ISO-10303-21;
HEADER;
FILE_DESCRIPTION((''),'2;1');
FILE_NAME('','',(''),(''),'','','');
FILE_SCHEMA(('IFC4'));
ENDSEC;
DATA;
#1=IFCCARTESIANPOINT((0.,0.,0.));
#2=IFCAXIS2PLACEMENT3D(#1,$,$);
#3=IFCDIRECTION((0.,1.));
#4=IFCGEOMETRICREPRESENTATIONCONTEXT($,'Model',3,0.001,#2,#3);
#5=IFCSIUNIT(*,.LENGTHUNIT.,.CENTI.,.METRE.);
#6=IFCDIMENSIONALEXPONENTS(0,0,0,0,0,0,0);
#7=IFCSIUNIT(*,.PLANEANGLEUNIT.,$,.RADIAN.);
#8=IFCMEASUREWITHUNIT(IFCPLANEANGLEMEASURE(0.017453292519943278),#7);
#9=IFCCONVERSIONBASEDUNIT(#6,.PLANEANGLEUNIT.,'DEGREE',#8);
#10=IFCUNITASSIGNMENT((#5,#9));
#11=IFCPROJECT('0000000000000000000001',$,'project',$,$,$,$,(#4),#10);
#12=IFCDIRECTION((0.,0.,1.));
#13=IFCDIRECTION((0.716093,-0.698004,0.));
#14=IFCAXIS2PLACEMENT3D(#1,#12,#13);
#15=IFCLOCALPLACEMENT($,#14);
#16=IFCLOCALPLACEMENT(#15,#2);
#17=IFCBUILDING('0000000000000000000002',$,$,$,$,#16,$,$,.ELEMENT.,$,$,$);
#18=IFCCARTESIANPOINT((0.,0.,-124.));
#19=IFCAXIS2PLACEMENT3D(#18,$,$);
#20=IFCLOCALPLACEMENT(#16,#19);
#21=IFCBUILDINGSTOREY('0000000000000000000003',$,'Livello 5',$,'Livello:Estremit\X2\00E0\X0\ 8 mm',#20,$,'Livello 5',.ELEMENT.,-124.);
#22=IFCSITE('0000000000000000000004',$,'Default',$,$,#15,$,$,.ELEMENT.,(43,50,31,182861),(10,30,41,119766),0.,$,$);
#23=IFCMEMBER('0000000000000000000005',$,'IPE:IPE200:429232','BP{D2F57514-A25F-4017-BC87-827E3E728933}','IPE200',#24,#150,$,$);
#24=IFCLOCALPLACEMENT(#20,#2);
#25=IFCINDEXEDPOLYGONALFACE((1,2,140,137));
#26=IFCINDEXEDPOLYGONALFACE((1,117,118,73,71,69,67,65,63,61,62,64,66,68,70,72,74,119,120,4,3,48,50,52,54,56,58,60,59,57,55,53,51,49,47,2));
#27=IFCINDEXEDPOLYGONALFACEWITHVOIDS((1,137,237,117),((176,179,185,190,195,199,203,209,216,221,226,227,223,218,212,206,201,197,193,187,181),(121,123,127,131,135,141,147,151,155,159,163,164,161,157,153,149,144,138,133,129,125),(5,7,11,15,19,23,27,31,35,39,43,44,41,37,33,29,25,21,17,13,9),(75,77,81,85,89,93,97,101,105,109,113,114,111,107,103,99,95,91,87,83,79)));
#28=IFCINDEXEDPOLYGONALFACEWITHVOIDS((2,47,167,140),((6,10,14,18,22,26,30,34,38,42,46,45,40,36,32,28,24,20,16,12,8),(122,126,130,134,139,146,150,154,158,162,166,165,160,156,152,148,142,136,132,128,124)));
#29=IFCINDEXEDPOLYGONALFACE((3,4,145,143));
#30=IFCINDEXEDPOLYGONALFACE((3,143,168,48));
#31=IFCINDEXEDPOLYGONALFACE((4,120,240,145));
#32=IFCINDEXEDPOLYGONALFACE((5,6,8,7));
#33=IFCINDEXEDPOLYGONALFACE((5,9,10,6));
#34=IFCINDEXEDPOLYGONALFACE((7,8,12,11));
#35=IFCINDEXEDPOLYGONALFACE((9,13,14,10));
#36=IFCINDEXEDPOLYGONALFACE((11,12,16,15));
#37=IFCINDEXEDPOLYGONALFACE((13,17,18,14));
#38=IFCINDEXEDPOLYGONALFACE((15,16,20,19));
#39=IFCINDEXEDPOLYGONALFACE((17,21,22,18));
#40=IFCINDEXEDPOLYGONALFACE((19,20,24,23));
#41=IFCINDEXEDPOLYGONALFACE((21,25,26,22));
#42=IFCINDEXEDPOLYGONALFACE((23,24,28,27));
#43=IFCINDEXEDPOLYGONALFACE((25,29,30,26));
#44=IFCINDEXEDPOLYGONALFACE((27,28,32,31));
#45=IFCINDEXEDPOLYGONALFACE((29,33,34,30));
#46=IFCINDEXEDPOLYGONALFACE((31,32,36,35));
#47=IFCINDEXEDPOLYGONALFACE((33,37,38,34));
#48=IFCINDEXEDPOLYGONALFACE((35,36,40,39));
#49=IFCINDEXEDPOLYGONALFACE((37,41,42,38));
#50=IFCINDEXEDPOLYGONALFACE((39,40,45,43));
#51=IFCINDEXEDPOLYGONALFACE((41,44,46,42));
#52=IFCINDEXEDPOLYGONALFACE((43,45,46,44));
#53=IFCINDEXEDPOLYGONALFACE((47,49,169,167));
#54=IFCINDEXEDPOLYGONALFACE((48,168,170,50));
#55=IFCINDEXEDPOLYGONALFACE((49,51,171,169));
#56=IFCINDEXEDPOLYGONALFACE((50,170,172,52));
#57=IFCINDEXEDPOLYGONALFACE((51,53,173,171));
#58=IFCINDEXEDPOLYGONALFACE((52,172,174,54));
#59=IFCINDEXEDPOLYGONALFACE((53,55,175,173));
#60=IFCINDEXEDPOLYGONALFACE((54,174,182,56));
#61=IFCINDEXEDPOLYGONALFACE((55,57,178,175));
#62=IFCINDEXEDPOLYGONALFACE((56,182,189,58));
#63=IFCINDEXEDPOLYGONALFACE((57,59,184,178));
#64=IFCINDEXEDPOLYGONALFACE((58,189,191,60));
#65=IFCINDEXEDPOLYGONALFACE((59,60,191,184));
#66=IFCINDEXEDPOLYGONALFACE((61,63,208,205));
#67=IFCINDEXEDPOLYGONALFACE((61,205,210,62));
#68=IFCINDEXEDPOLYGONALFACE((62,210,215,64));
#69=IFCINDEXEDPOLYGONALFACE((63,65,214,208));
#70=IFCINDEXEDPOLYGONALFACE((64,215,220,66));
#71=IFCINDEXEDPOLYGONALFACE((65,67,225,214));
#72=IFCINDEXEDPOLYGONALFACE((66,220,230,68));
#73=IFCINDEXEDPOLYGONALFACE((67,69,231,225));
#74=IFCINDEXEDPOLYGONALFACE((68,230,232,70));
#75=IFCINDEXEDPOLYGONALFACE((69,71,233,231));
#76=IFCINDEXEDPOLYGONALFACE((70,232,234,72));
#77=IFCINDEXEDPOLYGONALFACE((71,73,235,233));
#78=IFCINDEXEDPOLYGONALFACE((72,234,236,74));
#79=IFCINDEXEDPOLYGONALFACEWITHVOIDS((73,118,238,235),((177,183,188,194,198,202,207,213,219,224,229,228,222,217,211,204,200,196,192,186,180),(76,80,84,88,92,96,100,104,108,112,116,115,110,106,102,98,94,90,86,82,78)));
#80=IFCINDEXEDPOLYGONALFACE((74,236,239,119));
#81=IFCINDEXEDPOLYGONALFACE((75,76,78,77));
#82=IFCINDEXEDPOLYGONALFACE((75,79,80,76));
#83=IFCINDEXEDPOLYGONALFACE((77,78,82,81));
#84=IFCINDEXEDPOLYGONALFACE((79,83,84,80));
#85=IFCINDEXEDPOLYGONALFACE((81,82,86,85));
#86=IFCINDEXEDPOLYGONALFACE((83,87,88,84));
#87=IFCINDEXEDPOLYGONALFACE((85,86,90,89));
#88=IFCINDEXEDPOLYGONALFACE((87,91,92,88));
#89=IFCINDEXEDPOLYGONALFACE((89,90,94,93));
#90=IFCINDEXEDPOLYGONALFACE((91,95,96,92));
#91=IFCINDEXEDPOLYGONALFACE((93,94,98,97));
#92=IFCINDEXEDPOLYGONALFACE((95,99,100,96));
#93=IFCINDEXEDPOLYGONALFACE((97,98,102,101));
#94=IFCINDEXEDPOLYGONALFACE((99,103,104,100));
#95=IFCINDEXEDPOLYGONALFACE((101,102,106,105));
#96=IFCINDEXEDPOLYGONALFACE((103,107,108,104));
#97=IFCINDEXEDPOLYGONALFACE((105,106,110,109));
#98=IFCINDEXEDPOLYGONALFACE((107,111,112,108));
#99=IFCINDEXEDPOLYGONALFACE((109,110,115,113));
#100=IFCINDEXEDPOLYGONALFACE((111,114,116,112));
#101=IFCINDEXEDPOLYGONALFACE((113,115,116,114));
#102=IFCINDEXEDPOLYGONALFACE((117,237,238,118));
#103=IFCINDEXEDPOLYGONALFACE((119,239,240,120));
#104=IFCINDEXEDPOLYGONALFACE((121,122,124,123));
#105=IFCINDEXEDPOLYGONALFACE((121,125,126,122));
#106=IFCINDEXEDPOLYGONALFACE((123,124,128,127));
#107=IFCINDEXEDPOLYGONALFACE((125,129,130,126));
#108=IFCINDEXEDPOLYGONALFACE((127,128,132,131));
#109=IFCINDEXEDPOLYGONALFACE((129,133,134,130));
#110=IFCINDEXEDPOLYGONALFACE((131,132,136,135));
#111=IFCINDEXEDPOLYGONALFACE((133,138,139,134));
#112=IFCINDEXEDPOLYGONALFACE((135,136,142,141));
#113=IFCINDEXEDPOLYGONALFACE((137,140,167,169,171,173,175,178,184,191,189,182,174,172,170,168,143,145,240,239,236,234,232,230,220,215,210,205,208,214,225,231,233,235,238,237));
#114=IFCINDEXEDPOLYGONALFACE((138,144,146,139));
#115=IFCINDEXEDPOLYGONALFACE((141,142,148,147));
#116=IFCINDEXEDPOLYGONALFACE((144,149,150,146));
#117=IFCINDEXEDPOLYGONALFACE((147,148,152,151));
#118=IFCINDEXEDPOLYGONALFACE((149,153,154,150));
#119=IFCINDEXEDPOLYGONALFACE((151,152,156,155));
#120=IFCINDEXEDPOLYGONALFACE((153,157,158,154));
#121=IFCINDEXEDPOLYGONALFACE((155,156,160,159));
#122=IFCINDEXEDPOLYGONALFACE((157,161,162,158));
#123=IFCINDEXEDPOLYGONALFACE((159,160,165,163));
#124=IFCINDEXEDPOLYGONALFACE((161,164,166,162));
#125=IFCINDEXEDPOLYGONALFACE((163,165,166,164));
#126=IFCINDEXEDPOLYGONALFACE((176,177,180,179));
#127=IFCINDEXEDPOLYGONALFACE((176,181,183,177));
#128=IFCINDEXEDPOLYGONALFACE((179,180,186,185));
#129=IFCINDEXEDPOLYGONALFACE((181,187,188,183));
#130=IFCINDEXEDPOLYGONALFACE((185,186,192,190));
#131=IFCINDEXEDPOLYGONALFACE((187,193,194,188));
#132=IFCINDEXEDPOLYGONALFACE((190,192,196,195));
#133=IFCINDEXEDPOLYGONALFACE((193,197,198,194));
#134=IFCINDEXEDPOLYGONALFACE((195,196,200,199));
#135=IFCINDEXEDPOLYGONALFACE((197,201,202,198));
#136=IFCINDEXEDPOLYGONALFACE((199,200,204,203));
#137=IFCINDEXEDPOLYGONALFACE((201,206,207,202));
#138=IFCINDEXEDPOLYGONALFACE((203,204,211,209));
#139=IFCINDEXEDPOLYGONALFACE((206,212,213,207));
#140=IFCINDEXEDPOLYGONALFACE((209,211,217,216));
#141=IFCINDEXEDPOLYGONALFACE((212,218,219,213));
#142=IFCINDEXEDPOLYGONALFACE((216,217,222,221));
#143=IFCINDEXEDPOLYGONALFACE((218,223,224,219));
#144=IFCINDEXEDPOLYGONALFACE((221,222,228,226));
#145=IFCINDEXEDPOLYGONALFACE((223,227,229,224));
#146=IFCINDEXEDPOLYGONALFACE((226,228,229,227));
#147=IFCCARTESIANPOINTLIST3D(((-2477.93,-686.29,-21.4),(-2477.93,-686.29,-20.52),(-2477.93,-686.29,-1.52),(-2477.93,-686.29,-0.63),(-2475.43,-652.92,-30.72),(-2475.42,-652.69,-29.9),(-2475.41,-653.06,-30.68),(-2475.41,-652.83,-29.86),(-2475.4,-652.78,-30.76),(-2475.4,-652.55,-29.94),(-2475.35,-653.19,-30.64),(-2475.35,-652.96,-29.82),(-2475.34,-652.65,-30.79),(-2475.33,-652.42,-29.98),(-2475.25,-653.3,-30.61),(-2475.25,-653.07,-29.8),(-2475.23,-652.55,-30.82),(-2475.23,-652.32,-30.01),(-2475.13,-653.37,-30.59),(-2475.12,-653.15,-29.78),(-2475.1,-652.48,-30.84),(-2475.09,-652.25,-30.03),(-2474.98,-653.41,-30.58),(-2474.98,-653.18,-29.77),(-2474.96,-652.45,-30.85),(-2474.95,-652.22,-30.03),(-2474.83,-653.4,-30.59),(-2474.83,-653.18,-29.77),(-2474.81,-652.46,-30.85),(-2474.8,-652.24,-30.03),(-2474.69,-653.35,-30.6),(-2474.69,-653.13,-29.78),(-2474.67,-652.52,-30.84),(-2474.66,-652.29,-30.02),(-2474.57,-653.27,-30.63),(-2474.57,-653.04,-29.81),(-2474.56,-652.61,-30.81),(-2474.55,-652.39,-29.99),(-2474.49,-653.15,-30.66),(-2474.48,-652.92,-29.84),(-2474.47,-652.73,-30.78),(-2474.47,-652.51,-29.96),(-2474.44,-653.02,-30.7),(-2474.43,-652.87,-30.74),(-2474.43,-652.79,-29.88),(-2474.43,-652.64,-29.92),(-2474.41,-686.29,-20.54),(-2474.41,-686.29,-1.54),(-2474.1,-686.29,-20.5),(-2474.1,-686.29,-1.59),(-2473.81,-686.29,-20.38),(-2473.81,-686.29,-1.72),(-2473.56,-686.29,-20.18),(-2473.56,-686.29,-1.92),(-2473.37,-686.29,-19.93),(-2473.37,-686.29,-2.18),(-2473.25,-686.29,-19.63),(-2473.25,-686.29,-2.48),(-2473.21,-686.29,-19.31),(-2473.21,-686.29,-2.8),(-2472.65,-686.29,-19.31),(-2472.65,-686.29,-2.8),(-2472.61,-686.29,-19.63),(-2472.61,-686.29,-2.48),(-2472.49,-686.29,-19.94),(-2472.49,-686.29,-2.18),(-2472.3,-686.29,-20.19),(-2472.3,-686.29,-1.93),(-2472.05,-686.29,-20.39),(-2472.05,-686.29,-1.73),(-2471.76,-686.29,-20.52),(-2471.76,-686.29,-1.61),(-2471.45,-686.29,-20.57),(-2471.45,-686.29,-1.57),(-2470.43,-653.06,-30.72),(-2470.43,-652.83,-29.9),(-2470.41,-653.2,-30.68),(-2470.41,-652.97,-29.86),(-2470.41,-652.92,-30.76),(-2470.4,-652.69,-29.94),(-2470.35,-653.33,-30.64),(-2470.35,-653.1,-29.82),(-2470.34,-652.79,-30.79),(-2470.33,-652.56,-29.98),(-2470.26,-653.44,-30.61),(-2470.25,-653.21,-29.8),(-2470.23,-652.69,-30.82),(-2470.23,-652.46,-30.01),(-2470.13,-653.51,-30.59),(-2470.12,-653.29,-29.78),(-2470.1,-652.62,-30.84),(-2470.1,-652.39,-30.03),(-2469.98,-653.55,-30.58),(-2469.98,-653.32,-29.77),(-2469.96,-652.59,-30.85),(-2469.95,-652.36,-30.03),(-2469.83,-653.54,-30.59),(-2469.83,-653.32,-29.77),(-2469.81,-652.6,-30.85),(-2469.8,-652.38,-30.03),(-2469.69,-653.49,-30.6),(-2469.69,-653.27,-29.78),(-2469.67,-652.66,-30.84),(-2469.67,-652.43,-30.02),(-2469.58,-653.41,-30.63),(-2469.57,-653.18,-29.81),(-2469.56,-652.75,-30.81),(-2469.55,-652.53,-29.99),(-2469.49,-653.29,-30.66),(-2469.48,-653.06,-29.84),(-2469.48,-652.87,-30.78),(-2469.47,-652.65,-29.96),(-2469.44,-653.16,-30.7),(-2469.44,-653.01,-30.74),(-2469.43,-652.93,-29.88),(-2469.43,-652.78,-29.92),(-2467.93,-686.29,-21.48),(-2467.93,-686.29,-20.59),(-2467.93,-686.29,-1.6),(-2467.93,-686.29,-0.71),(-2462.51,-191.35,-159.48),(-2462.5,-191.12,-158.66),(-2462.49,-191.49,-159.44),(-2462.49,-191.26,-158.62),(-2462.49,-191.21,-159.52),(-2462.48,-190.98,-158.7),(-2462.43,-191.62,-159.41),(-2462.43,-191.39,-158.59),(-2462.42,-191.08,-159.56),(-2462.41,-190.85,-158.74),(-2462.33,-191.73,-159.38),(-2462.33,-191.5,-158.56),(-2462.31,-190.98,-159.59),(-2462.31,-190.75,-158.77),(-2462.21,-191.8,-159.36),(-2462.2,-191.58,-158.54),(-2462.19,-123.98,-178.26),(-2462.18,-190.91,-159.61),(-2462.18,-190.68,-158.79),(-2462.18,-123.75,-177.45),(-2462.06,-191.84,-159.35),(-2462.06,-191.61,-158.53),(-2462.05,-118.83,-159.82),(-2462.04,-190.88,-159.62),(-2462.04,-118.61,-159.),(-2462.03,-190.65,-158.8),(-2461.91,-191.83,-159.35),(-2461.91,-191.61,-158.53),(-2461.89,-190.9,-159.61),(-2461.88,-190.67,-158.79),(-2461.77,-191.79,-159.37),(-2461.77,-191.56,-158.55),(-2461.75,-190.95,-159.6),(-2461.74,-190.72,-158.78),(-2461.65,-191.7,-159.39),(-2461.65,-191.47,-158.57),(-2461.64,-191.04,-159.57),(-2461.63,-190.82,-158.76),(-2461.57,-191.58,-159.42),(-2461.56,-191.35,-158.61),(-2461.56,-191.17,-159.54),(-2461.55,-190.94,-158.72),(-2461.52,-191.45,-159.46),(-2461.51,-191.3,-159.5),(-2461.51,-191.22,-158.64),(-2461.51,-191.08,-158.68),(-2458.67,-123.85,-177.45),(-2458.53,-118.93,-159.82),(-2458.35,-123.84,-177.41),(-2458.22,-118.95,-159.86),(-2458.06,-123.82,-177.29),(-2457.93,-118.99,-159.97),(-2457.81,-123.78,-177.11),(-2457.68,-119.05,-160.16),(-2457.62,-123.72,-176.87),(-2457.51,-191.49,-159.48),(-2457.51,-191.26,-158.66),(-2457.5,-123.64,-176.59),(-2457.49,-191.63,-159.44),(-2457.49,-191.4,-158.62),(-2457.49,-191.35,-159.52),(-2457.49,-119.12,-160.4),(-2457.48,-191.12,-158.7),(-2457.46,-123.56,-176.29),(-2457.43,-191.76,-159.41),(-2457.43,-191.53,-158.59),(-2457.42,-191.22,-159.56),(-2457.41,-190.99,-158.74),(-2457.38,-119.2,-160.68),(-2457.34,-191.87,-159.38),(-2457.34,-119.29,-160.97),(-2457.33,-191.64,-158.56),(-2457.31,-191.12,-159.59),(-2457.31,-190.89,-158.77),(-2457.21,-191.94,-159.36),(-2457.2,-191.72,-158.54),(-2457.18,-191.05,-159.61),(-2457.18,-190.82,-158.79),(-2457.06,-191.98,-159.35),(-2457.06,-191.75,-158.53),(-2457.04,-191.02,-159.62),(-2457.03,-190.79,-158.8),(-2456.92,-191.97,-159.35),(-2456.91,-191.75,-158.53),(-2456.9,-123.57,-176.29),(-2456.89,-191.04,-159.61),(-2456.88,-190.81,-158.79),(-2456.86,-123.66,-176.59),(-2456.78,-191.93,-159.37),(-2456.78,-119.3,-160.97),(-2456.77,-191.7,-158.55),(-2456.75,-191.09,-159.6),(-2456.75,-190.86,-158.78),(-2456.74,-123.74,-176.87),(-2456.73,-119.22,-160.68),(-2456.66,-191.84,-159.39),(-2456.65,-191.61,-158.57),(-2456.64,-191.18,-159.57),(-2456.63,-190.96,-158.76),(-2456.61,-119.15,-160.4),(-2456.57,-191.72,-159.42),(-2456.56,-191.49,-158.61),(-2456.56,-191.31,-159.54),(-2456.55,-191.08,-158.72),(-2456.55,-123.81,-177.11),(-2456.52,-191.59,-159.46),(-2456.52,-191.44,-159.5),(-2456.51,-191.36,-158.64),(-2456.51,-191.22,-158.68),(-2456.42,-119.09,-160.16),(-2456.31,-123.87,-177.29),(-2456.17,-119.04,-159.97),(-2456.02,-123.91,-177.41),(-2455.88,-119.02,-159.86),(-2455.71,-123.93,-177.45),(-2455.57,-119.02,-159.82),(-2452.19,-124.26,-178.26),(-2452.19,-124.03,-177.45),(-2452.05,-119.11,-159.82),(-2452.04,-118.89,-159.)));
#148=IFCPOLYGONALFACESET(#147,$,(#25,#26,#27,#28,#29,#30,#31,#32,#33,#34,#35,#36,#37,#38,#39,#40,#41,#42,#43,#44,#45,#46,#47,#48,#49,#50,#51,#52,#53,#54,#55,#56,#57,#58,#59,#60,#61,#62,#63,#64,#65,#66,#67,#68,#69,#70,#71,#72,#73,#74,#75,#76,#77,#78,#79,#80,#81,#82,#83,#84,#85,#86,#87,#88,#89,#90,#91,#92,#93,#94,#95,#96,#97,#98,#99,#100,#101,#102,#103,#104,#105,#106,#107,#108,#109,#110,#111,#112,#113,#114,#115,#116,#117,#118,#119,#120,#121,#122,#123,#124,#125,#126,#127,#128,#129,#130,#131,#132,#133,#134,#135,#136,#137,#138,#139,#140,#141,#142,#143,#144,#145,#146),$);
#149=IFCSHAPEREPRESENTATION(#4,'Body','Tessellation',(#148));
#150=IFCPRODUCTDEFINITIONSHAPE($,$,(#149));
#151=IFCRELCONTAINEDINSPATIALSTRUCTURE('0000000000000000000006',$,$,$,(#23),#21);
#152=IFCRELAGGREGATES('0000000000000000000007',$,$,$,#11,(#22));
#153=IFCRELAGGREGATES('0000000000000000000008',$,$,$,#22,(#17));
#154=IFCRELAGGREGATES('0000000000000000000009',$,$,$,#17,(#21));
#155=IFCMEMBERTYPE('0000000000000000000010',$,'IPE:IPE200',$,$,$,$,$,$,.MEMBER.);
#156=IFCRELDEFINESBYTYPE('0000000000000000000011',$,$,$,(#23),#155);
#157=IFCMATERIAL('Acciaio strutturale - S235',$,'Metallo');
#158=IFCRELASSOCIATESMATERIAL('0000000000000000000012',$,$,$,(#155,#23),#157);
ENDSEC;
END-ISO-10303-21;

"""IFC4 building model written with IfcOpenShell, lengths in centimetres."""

from ifc_helpers import new_model, entity, si_unit, converted_unit, direction, frame, frame_2d, origin, origin_2d, place, context, project, spatial, circle, i_section, extrude, clip, halfspace, material, type_object, element, save


model = new_model("IFC4")

# Units and contexts
model_context = context("Model", 3, precision=0.001, world=origin(), true_north=direction((0.0, 1.0)))
ifc_project = project(units=[si_unit("LENGTHUNIT", "METRE", prefix="CENTI"), converted_unit("PLANEANGLEUNIT", "DEGREE", entity("IfcPlaneAngleMeasure", 0.017453292519943278), si_unit("PLANEANGLEUNIT", "RADIAN"), dimensions=[0, 0, 0, 0, 0, 0, 0])], contexts=[model_context])

# Site, building, storey
site_placement = place(None, frame((0.0, 0.0, 0.0), z_axis=(0.0, 0.0, 1.0), x_axis=(0.716093, -0.698004, 0.0)))
site = spatial("IfcSite", under=ifc_project, at=site_placement, Name="Default", CompositionType="ELEMENT", RefLatitude=(43, 50, 31, 182861), RefLongitude=(10, 30, 41, 119766), RefElevation=0.0)
building_placement = place(site_placement, origin())
building = spatial("IfcBuilding", under=site, at=building_placement, CompositionType="ELEMENT")
storey_placement = place(building_placement, frame((0.0, 0.0, -124.0)))
storey = spatial("IfcBuildingStorey", under=building, at=storey_placement, Name="Livello 5", ObjectType="Livello:Estremità 8 mm", LongName="Livello 5", CompositionType="ELEMENT", Elevation=-124.0)

# Shared definitions
ifc_material_1 = material(Name="Acciaio strutturale - S235", Category="Metallo")

# Member, openings
member_type_1 = type_object("IfcMemberType", Name="IPE:IPE200", PredefinedType="MEMBER", material=ifc_material_1)
member_1_placement = place(storey_placement, frame((-2474.04, -726.15, 0.07), z_axis=(-0.026952, -0.962871, 0.268612), x_axis=(0.999608, -0.02798, 0.0)))
member_1 = element("IfcMember", 1, at=member_1_placement, inside=storey, type_object=member_type_1, material=ifc_material_1, Name="IPE:IPE200:429232", Description="BP{D2F57514-A25F-4017-BC87-827E3E728933}", ObjectType="IPE200", context=model_context, shape_type="Clipping", body=[
    clip(extrude(i_section(OverallWidth=10.0, OverallDepth=20.0, WebThickness=0.56, FlangeThickness=0.85, FilletRadius=1.2, at=origin_2d()), origin(), (0.0, 0.0, -1.0), 628.04), halfspace(frame((2471.96, 148.68, -71.78), z_axis=(-0.02798, 0.268507, -0.962871), x_axis=(-0.999608, -0.007516, 0.026952)), True)),
])
opening_1_placement = place(member_1_placement, frame((1.56, -9.1, -78.75), z_axis=(0.0, 1.0, 0.0), x_axis=(-1.0, 0.0, 0.0)))
element("IfcOpeningElement", 2, at=opening_1_placement, cuts=member_1, ObjectType="Opening", context=model_context, shape_type="SweptSolid", body=[
    extrude(circle(Radius=0.5, at=frame_2d((-0.5, 0.0), x_axis=(1.0, 0.0))), origin(), (0.0, 0.0, -1.0), 0.95),
])
opening_2_placement = place(member_1_placement, frame((-3.44, -9.1, -78.75), z_axis=(0.0, 1.0, 0.0), x_axis=(-1.0, 0.0, 0.0)))
element("IfcOpeningElement", 3, at=opening_2_placement, cuts=member_1, ObjectType="Opening", context=model_context, shape_type="SweptSolid", body=[
    extrude(circle(Radius=0.5, at=frame_2d((-0.5, 0.0), x_axis=(1.0, 0.0))), origin(), (0.0, 0.0, -1.0), 0.95),
])
opening_3_placement = place(member_1_placement, frame((1.56, -9.1, -558.11), z_axis=(0.0, 1.0, 0.0), x_axis=(-1.0, 0.0, 0.0)))
element("IfcOpeningElement", 4, at=opening_3_placement, cuts=member_1, ObjectType="Opening", context=model_context, shape_type="SweptSolid", body=[
    extrude(circle(Radius=0.5, at=frame_2d((-0.5, 0.0), x_axis=(1.0, 0.0))), origin(), (0.0, 0.0, -1.0), 0.95),
])
opening_4_placement = place(member_1_placement, frame((-3.44, -9.1, -558.11), z_axis=(0.0, 1.0, 0.0), x_axis=(-1.0, 0.0, 0.0)))
element("IfcOpeningElement", 5, at=opening_4_placement, cuts=member_1, ObjectType="Opening", context=model_context, shape_type="SweptSolid", body=[
    extrude(circle(Radius=0.5, at=frame_2d((-0.5, 0.0), x_axis=(1.0, 0.0))), origin(), (0.0, 0.0, -1.0), 0.95),
])

save(model, "model.ifc")
